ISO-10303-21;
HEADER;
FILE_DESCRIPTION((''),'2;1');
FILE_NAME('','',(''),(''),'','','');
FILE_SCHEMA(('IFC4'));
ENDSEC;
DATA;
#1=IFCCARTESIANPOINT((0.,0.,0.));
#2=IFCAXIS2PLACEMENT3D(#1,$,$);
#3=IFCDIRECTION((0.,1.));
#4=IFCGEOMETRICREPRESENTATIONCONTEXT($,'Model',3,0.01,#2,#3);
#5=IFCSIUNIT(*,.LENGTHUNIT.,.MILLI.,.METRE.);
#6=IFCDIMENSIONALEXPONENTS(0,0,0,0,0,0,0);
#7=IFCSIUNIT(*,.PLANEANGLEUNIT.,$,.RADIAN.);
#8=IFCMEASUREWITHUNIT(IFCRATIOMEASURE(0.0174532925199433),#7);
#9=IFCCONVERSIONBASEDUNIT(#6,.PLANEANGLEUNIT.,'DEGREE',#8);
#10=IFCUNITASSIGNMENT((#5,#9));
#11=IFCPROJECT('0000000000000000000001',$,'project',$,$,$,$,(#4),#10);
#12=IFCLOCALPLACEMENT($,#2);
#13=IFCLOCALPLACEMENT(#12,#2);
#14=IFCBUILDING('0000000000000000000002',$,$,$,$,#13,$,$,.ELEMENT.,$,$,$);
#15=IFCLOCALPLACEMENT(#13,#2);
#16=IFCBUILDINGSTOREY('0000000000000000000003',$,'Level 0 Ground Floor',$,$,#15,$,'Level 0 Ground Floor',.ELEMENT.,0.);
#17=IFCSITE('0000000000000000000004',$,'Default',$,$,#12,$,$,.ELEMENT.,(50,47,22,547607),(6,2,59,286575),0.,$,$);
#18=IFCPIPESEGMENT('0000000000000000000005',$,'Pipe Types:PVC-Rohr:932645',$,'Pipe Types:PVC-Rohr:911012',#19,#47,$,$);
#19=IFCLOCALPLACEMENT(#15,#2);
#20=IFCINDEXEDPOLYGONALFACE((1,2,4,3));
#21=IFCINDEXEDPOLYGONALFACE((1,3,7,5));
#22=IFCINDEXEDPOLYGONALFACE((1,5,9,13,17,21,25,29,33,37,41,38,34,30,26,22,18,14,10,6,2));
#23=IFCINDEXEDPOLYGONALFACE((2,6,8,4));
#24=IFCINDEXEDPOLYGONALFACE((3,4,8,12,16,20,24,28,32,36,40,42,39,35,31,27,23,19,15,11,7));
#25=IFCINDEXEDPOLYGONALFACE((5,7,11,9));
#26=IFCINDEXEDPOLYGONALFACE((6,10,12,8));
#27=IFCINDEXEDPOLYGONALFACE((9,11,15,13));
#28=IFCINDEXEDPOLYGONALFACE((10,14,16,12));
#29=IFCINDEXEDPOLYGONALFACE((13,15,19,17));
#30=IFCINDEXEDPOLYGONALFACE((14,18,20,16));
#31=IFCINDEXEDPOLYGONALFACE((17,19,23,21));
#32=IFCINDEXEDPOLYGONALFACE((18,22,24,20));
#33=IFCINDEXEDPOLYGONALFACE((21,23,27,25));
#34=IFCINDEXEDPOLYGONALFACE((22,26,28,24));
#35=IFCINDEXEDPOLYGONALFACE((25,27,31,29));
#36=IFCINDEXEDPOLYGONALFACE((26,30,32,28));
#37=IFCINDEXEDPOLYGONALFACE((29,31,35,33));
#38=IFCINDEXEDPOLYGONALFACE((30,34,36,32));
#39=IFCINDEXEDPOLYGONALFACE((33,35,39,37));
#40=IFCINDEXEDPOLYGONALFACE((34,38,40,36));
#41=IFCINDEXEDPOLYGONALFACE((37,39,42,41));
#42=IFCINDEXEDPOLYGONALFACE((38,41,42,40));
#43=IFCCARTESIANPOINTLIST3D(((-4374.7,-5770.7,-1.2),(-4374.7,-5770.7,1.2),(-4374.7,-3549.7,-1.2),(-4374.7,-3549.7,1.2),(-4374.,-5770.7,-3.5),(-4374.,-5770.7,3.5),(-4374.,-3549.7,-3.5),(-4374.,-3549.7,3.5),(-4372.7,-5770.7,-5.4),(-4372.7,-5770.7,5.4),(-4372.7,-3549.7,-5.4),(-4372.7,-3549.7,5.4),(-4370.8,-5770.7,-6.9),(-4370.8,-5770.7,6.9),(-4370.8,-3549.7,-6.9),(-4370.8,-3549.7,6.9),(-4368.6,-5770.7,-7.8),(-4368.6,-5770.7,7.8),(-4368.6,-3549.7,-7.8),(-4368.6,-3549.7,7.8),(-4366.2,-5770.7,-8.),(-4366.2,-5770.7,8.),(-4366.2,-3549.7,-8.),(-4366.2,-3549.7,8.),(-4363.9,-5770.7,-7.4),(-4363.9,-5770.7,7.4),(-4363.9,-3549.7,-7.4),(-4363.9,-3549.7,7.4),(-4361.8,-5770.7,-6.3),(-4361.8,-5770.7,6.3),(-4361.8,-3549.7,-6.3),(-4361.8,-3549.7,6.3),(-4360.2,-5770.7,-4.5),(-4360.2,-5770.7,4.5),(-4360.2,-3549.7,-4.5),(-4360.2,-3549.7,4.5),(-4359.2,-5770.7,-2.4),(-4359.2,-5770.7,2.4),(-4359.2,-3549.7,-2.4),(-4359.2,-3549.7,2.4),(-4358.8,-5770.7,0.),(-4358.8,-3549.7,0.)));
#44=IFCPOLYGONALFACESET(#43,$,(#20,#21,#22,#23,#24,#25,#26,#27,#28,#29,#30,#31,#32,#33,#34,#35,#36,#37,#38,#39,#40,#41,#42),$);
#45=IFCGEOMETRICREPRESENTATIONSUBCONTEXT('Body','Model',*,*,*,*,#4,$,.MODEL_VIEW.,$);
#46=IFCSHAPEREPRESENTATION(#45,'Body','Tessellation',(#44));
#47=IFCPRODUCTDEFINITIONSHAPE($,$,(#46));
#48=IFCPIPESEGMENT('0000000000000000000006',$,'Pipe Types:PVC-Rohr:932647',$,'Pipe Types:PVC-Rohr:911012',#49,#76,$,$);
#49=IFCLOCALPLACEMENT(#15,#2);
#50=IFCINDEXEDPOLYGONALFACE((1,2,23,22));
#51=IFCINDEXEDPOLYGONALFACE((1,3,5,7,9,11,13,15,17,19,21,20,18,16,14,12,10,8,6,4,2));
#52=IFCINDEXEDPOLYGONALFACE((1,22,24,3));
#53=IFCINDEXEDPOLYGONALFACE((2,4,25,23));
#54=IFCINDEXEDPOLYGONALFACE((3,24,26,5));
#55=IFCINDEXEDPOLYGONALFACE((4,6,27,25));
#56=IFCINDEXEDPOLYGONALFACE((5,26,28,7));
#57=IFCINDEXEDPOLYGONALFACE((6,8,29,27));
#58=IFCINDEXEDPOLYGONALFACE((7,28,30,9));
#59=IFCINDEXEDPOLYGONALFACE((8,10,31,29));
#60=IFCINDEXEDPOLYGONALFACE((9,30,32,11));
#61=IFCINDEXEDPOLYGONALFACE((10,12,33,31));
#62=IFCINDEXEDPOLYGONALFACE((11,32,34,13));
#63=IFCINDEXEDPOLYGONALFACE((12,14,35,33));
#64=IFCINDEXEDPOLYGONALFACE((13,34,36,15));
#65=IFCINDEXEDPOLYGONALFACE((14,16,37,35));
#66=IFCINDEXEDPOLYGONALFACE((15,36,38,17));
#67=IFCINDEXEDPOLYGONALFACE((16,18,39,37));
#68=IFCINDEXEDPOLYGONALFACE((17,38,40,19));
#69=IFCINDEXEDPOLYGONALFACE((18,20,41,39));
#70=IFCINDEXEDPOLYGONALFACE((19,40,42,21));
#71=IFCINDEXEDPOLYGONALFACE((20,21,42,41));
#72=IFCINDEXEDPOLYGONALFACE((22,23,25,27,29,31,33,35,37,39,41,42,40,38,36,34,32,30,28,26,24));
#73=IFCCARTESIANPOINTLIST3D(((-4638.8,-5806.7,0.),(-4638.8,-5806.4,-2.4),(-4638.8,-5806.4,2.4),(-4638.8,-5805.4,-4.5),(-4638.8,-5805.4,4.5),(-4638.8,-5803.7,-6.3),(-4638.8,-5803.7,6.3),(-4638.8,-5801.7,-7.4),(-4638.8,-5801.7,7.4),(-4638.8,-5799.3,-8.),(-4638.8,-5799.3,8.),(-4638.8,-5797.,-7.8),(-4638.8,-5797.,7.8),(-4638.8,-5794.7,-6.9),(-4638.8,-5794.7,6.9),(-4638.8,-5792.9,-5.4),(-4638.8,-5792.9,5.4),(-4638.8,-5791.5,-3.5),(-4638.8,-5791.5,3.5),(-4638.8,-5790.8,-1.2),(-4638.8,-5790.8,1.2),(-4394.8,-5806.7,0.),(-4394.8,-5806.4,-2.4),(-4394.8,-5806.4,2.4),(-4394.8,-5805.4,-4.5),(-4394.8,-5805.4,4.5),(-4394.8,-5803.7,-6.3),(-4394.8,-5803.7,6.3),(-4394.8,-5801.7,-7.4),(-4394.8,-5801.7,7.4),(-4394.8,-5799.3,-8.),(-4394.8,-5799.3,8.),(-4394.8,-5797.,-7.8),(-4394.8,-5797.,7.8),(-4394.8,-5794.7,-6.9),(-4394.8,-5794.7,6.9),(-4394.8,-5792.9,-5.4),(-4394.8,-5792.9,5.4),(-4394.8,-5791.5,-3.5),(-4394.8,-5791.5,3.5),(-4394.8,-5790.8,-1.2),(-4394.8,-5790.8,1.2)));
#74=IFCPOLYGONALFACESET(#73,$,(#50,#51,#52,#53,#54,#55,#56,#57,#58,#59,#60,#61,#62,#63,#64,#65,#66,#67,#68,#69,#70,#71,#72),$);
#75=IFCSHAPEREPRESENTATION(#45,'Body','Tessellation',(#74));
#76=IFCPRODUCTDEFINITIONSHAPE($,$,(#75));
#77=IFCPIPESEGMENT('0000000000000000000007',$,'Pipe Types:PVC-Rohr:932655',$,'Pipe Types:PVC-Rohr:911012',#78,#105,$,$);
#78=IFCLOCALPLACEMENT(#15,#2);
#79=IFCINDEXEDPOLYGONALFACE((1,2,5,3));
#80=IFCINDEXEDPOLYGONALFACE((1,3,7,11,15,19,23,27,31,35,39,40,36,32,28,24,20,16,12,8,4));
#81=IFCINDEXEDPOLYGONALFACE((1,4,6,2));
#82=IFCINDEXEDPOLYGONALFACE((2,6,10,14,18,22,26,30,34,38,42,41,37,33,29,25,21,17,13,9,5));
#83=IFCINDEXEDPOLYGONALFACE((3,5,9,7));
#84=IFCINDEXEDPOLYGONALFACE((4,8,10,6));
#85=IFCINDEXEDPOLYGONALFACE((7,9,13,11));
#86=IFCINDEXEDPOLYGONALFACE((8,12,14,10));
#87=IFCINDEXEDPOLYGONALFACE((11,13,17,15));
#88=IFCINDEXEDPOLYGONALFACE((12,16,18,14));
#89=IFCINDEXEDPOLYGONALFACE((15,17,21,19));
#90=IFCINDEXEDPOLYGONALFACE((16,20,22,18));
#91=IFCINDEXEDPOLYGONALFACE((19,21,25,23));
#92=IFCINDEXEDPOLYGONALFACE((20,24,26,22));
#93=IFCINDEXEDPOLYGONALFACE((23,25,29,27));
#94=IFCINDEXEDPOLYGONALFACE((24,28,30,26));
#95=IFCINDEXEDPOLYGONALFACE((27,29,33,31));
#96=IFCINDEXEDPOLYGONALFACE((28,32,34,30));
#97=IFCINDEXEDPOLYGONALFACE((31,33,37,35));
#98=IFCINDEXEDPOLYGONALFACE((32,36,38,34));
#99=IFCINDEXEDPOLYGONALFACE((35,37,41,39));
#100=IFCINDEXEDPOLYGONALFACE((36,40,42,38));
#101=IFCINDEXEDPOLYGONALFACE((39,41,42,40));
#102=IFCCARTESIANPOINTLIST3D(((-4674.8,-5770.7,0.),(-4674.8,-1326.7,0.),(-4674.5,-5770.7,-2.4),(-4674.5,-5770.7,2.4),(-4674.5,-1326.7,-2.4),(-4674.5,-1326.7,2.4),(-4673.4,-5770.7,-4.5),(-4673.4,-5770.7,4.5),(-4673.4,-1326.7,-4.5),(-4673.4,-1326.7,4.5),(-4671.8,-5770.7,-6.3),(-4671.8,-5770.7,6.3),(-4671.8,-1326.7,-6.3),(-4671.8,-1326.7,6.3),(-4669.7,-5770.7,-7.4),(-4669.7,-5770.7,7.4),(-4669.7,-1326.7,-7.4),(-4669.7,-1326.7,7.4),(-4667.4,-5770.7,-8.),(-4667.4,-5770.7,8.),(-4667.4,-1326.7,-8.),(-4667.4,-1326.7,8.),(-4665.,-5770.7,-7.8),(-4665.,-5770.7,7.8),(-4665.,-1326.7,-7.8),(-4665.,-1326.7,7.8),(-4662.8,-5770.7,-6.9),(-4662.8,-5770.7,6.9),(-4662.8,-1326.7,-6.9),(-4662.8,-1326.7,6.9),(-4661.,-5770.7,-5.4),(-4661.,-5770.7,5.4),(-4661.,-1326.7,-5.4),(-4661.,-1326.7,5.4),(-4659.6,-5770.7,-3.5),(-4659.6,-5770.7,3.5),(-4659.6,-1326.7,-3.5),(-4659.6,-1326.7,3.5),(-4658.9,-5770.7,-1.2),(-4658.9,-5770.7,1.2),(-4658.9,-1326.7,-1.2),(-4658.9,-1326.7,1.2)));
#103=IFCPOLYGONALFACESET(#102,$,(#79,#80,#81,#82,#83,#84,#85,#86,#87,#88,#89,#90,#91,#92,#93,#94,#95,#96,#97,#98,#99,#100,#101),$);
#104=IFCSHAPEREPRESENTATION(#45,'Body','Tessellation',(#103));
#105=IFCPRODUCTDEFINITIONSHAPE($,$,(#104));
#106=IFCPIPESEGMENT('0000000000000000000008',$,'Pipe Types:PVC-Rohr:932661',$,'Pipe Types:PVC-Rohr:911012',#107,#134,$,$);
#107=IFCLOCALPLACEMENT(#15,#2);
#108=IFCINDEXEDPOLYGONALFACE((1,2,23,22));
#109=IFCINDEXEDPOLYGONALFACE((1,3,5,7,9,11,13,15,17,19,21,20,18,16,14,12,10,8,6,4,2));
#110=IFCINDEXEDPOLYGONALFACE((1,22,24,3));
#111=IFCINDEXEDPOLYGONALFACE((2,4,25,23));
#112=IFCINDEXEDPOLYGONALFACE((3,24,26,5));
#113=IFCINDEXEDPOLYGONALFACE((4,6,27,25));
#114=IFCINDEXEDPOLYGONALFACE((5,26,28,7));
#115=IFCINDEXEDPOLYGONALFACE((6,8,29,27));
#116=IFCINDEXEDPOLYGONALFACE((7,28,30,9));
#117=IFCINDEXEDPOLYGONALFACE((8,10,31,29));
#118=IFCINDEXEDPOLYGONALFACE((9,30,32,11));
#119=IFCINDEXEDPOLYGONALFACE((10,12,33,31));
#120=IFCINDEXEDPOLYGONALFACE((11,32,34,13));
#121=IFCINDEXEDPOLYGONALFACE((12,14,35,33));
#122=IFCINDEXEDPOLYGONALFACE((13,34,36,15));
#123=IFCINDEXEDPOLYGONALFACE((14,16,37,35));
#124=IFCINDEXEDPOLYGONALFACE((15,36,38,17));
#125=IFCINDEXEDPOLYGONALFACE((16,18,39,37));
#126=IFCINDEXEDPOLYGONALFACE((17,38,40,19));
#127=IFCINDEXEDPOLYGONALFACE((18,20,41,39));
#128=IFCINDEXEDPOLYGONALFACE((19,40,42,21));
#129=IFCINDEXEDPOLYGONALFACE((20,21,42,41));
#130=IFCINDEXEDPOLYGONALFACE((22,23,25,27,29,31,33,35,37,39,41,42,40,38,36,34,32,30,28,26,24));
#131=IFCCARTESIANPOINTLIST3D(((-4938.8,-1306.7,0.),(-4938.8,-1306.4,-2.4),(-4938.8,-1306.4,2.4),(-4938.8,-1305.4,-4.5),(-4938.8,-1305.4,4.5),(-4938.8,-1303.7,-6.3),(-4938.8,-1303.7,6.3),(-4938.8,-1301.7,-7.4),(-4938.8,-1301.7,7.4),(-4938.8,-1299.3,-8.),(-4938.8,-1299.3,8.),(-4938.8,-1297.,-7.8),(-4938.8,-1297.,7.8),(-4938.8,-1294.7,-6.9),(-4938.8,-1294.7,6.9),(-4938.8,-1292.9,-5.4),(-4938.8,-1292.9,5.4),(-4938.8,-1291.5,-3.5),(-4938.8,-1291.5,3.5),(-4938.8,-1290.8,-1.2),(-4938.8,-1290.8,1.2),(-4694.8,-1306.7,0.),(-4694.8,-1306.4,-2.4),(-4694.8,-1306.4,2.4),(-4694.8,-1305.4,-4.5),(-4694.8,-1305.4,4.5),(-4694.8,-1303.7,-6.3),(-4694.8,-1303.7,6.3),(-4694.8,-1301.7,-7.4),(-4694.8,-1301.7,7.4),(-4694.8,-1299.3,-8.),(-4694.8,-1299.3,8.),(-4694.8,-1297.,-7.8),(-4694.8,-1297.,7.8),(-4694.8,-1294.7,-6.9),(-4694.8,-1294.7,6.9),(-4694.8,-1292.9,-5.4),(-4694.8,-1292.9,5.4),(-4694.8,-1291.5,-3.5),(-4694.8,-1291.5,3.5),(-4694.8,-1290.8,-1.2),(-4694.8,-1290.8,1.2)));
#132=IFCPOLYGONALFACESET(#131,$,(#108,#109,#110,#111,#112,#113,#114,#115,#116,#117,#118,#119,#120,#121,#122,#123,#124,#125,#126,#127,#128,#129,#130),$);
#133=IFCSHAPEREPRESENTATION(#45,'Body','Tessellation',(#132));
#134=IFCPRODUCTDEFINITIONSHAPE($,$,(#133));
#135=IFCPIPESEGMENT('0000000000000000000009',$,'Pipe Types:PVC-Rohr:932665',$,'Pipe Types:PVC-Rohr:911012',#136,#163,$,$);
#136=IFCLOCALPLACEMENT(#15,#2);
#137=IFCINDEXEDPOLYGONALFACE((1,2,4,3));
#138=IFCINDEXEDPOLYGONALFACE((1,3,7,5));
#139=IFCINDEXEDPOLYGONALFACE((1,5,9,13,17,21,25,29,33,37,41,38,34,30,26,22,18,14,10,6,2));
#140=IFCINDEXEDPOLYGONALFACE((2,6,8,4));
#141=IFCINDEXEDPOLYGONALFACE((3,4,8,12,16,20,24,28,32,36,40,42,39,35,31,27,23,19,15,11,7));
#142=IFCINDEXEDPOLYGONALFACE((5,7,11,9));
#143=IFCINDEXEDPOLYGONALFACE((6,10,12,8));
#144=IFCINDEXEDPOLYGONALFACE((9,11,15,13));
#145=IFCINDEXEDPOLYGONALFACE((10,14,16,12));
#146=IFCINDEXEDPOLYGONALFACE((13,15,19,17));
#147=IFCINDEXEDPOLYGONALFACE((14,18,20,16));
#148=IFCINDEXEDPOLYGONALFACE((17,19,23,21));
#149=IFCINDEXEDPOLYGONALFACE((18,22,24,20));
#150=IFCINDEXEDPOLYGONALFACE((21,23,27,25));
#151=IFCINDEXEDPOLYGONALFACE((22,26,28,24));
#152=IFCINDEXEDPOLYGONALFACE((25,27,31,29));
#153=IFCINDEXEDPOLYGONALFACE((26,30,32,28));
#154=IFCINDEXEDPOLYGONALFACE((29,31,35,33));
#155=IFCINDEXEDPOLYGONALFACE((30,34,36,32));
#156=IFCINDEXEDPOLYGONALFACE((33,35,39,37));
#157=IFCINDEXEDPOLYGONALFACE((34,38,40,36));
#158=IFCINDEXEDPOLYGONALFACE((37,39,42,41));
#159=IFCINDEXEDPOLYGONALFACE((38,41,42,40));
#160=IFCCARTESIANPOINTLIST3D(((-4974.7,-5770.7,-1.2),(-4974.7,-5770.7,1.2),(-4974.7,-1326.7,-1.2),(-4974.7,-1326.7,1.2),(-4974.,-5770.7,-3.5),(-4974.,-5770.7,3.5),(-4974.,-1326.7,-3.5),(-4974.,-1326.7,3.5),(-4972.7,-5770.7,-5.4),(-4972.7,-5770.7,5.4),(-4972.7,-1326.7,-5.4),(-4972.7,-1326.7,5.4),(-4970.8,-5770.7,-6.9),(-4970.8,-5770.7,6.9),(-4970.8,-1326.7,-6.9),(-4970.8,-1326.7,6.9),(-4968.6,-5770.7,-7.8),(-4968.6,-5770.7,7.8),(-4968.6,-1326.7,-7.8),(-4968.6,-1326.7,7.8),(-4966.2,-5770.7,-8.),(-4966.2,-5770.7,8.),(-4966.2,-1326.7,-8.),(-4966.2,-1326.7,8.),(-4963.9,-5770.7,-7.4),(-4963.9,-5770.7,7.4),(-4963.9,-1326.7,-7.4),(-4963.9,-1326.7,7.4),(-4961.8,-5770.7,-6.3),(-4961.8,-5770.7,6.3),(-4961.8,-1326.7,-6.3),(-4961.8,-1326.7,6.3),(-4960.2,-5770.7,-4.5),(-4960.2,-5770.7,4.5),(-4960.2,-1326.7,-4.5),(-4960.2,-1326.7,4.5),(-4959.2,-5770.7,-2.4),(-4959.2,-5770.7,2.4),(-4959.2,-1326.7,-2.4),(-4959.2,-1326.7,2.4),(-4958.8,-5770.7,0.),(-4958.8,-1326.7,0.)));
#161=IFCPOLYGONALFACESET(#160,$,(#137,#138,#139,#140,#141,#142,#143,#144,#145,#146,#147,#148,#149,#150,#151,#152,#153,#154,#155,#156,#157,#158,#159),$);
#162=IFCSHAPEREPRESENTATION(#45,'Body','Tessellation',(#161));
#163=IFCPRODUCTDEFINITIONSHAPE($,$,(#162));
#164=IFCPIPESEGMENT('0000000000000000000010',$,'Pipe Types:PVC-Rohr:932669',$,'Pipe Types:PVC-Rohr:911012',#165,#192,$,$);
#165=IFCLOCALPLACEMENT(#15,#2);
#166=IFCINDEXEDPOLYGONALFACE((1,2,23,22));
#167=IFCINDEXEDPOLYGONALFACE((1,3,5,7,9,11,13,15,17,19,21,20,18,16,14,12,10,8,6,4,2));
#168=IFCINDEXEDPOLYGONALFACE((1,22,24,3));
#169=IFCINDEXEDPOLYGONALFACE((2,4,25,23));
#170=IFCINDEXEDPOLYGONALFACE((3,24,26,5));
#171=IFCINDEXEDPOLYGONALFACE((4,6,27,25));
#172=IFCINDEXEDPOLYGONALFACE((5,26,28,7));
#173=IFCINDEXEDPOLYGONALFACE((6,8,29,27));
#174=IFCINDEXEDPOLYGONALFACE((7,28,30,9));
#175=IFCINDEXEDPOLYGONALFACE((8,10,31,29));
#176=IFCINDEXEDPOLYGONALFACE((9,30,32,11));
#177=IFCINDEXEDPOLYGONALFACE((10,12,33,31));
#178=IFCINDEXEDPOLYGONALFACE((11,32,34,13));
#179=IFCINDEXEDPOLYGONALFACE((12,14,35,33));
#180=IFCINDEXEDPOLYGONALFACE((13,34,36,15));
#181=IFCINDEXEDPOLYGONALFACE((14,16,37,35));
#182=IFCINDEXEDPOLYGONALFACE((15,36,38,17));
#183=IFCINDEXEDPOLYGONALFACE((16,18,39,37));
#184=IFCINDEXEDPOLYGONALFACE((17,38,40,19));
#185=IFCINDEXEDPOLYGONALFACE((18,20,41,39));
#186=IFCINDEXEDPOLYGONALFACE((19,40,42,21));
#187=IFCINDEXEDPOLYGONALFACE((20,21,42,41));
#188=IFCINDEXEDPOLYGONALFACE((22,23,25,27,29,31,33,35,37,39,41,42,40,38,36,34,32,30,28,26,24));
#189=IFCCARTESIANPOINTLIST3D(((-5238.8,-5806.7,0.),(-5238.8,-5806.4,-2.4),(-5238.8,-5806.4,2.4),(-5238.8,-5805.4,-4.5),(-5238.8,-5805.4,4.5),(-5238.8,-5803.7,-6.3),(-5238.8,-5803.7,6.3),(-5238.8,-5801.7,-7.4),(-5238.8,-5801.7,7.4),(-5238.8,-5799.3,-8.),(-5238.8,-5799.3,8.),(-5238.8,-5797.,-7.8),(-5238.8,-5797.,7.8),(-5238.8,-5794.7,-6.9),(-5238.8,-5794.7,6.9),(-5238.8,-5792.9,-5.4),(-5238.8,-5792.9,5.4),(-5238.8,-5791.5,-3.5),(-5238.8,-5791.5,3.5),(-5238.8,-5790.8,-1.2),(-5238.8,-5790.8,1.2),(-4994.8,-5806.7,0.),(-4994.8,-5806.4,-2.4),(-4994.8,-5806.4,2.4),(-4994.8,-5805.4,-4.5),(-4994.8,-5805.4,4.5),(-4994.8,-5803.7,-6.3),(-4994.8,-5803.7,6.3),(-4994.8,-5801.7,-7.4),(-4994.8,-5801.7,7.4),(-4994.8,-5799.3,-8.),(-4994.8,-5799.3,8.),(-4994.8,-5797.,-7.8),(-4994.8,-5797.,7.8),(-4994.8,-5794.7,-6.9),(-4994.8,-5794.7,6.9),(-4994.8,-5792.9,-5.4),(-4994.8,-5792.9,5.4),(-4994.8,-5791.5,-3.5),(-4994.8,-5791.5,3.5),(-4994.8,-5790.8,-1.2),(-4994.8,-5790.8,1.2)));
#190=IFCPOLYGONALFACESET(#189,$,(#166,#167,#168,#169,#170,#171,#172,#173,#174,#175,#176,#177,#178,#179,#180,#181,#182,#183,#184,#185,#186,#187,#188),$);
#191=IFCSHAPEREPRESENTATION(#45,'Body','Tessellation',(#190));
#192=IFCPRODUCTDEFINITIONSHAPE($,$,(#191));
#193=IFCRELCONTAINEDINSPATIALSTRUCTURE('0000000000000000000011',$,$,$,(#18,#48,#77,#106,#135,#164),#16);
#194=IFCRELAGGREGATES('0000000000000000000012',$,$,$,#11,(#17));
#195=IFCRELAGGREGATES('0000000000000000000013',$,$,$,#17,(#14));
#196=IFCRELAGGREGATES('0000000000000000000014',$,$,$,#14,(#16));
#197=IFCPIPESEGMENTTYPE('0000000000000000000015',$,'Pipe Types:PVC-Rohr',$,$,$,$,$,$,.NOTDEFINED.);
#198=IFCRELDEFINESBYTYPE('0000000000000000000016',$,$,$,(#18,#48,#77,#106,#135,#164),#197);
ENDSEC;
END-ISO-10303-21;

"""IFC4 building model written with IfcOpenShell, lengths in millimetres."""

from ifc_helpers import new_model, entity, si_unit, converted_unit, direction, frame, frame_2d, origin, place, context, subcontext, project, spatial, circle, extrude, type_object, element, save


model = new_model("IFC4")

# Units and contexts
model_context = context("Model", 3, precision=0.01, world=origin(), true_north=direction((0.0, 1.0)))
body_context = subcontext(model_context, "Body", "Model", "MODEL_VIEW")
ifc_project = project(units=[si_unit("LENGTHUNIT", "METRE", prefix="MILLI"), converted_unit("PLANEANGLEUNIT", "DEGREE", entity("IfcRatioMeasure", 0.0174532925199433), si_unit("PLANEANGLEUNIT", "RADIAN"), dimensions=[0, 0, 0, 0, 0, 0, 0])], contexts=[model_context])

# Site, building, storey
site_placement = place(None, origin())
site = spatial("IfcSite", under=ifc_project, at=site_placement, Name="Default", CompositionType="ELEMENT", RefLatitude=(50, 47, 22, 547607), RefLongitude=(6, 2, 59, 286575), RefElevation=0.0)
building_placement = place(site_placement, origin())
building = spatial("IfcBuilding", under=site, at=building_placement, CompositionType="ELEMENT")
storey_placement = place(building_placement, origin())
storey = spatial("IfcBuildingStorey", under=building, at=storey_placement, Name="Level 0 Ground Floor", LongName="Level 0 Ground Floor", CompositionType="ELEMENT", Elevation=0.0)

# Pipe segments
pipe_segment_type = type_object("IfcPipeSegmentType", Name="Pipe Types:PVC-Rohr", PredefinedType="NOTDEFINED")
pipe_segment_1_placement = place(storey_placement, frame((-4376.4, -5770.7, -9.6)))
element("IfcPipeSegment", 1, at=pipe_segment_1_placement, inside=storey, type_object=pipe_segment_type, Name="Pipe Types:PVC-Rohr:932645", ObjectType="Pipe Types:PVC-Rohr:911012", context=body_context, shape_type="SweptSolid", body=[
    extrude(circle(Radius=8.0, at=frame_2d((0.0, 0.0), x_axis=(1.0, 0.0))), frame((9.6, 0.0, 9.6), z_axis=(0.0, 1.0, 0.0), x_axis=(1.0, 0.0, 0.0)), (0.0, 0.0, 1.0), 2221.0),
])
pipe_segment_2_placement = place(storey_placement, frame((-4638.8, -5808.3, -9.6)))
element("IfcPipeSegment", 2, at=pipe_segment_2_placement, inside=storey, type_object=pipe_segment_type, Name="Pipe Types:PVC-Rohr:932647", ObjectType="Pipe Types:PVC-Rohr:911012", context=body_context, shape_type="SweptSolid", body=[
    extrude(circle(Radius=8.0, at=frame_2d((0.0, 0.0), x_axis=(1.0, 0.0))), frame((0.0, 9.6, 9.6), z_axis=(1.0, 0.0, 0.0), x_axis=(0.0, -1.0, 0.0)), (0.0, 0.0, 1.0), 244.0),
])
pipe_segment_3_placement = place(storey_placement, frame((-4676.4, -5770.7, -9.6)))
element("IfcPipeSegment", 3, at=pipe_segment_3_placement, inside=storey, type_object=pipe_segment_type, Name="Pipe Types:PVC-Rohr:932655", ObjectType="Pipe Types:PVC-Rohr:911012", context=body_context, shape_type="SweptSolid", body=[
    extrude(circle(Radius=8.0, at=frame_2d((0.0, 0.0), x_axis=(1.0, 0.0))), frame((9.6, 0.0, 9.6), z_axis=(0.0, 1.0, 0.0), x_axis=(-1.0, 0.0, 0.0)), (0.0, 0.0, 1.0), 4444.0),
])
pipe_segment_4_placement = place(storey_placement, frame((-4938.8, -1308.3, -9.6)))
element("IfcPipeSegment", 4, at=pipe_segment_4_placement, inside=storey, type_object=pipe_segment_type, Name="Pipe Types:PVC-Rohr:932661", ObjectType="Pipe Types:PVC-Rohr:911012", context=body_context, shape_type="SweptSolid", body=[
    extrude(circle(Radius=8.0, at=frame_2d((0.0, 0.0), x_axis=(1.0, 0.0))), frame((0.0, 9.6, 9.6), z_axis=(1.0, 0.0, 0.0), x_axis=(0.0, -1.0, 0.0)), (0.0, 0.0, 1.0), 244.0),
])
pipe_segment_5_placement = place(storey_placement, frame((-4976.4, -5770.7, -9.6)))
element("IfcPipeSegment", 5, at=pipe_segment_5_placement, inside=storey, type_object=pipe_segment_type, Name="Pipe Types:PVC-Rohr:932665", ObjectType="Pipe Types:PVC-Rohr:911012", context=body_context, shape_type="SweptSolid", body=[
    extrude(circle(Radius=8.0, at=frame_2d((0.0, 0.0), x_axis=(1.0, 0.0))), frame((9.6, 0.0, 9.6), z_axis=(0.0, 1.0, 0.0), x_axis=(1.0, 0.0, 0.0)), (0.0, 0.0, 1.0), 4444.0),
])
pipe_segment_6_placement = place(storey_placement, frame((-5238.8, -5808.3, -9.6)))
element("IfcPipeSegment", 6, at=pipe_segment_6_placement, inside=storey, type_object=pipe_segment_type, Name="Pipe Types:PVC-Rohr:932669", ObjectType="Pipe Types:PVC-Rohr:911012", context=body_context, shape_type="SweptSolid", body=[
    extrude(circle(Radius=8.0, at=frame_2d((0.0, 0.0), x_axis=(1.0, 0.0))), frame((0.0, 9.6, 9.6), z_axis=(1.0, 0.0, 0.0), x_axis=(0.0, -1.0, 0.0)), (0.0, 0.0, 1.0), 244.0),
])

save(model, "model.ifc")
